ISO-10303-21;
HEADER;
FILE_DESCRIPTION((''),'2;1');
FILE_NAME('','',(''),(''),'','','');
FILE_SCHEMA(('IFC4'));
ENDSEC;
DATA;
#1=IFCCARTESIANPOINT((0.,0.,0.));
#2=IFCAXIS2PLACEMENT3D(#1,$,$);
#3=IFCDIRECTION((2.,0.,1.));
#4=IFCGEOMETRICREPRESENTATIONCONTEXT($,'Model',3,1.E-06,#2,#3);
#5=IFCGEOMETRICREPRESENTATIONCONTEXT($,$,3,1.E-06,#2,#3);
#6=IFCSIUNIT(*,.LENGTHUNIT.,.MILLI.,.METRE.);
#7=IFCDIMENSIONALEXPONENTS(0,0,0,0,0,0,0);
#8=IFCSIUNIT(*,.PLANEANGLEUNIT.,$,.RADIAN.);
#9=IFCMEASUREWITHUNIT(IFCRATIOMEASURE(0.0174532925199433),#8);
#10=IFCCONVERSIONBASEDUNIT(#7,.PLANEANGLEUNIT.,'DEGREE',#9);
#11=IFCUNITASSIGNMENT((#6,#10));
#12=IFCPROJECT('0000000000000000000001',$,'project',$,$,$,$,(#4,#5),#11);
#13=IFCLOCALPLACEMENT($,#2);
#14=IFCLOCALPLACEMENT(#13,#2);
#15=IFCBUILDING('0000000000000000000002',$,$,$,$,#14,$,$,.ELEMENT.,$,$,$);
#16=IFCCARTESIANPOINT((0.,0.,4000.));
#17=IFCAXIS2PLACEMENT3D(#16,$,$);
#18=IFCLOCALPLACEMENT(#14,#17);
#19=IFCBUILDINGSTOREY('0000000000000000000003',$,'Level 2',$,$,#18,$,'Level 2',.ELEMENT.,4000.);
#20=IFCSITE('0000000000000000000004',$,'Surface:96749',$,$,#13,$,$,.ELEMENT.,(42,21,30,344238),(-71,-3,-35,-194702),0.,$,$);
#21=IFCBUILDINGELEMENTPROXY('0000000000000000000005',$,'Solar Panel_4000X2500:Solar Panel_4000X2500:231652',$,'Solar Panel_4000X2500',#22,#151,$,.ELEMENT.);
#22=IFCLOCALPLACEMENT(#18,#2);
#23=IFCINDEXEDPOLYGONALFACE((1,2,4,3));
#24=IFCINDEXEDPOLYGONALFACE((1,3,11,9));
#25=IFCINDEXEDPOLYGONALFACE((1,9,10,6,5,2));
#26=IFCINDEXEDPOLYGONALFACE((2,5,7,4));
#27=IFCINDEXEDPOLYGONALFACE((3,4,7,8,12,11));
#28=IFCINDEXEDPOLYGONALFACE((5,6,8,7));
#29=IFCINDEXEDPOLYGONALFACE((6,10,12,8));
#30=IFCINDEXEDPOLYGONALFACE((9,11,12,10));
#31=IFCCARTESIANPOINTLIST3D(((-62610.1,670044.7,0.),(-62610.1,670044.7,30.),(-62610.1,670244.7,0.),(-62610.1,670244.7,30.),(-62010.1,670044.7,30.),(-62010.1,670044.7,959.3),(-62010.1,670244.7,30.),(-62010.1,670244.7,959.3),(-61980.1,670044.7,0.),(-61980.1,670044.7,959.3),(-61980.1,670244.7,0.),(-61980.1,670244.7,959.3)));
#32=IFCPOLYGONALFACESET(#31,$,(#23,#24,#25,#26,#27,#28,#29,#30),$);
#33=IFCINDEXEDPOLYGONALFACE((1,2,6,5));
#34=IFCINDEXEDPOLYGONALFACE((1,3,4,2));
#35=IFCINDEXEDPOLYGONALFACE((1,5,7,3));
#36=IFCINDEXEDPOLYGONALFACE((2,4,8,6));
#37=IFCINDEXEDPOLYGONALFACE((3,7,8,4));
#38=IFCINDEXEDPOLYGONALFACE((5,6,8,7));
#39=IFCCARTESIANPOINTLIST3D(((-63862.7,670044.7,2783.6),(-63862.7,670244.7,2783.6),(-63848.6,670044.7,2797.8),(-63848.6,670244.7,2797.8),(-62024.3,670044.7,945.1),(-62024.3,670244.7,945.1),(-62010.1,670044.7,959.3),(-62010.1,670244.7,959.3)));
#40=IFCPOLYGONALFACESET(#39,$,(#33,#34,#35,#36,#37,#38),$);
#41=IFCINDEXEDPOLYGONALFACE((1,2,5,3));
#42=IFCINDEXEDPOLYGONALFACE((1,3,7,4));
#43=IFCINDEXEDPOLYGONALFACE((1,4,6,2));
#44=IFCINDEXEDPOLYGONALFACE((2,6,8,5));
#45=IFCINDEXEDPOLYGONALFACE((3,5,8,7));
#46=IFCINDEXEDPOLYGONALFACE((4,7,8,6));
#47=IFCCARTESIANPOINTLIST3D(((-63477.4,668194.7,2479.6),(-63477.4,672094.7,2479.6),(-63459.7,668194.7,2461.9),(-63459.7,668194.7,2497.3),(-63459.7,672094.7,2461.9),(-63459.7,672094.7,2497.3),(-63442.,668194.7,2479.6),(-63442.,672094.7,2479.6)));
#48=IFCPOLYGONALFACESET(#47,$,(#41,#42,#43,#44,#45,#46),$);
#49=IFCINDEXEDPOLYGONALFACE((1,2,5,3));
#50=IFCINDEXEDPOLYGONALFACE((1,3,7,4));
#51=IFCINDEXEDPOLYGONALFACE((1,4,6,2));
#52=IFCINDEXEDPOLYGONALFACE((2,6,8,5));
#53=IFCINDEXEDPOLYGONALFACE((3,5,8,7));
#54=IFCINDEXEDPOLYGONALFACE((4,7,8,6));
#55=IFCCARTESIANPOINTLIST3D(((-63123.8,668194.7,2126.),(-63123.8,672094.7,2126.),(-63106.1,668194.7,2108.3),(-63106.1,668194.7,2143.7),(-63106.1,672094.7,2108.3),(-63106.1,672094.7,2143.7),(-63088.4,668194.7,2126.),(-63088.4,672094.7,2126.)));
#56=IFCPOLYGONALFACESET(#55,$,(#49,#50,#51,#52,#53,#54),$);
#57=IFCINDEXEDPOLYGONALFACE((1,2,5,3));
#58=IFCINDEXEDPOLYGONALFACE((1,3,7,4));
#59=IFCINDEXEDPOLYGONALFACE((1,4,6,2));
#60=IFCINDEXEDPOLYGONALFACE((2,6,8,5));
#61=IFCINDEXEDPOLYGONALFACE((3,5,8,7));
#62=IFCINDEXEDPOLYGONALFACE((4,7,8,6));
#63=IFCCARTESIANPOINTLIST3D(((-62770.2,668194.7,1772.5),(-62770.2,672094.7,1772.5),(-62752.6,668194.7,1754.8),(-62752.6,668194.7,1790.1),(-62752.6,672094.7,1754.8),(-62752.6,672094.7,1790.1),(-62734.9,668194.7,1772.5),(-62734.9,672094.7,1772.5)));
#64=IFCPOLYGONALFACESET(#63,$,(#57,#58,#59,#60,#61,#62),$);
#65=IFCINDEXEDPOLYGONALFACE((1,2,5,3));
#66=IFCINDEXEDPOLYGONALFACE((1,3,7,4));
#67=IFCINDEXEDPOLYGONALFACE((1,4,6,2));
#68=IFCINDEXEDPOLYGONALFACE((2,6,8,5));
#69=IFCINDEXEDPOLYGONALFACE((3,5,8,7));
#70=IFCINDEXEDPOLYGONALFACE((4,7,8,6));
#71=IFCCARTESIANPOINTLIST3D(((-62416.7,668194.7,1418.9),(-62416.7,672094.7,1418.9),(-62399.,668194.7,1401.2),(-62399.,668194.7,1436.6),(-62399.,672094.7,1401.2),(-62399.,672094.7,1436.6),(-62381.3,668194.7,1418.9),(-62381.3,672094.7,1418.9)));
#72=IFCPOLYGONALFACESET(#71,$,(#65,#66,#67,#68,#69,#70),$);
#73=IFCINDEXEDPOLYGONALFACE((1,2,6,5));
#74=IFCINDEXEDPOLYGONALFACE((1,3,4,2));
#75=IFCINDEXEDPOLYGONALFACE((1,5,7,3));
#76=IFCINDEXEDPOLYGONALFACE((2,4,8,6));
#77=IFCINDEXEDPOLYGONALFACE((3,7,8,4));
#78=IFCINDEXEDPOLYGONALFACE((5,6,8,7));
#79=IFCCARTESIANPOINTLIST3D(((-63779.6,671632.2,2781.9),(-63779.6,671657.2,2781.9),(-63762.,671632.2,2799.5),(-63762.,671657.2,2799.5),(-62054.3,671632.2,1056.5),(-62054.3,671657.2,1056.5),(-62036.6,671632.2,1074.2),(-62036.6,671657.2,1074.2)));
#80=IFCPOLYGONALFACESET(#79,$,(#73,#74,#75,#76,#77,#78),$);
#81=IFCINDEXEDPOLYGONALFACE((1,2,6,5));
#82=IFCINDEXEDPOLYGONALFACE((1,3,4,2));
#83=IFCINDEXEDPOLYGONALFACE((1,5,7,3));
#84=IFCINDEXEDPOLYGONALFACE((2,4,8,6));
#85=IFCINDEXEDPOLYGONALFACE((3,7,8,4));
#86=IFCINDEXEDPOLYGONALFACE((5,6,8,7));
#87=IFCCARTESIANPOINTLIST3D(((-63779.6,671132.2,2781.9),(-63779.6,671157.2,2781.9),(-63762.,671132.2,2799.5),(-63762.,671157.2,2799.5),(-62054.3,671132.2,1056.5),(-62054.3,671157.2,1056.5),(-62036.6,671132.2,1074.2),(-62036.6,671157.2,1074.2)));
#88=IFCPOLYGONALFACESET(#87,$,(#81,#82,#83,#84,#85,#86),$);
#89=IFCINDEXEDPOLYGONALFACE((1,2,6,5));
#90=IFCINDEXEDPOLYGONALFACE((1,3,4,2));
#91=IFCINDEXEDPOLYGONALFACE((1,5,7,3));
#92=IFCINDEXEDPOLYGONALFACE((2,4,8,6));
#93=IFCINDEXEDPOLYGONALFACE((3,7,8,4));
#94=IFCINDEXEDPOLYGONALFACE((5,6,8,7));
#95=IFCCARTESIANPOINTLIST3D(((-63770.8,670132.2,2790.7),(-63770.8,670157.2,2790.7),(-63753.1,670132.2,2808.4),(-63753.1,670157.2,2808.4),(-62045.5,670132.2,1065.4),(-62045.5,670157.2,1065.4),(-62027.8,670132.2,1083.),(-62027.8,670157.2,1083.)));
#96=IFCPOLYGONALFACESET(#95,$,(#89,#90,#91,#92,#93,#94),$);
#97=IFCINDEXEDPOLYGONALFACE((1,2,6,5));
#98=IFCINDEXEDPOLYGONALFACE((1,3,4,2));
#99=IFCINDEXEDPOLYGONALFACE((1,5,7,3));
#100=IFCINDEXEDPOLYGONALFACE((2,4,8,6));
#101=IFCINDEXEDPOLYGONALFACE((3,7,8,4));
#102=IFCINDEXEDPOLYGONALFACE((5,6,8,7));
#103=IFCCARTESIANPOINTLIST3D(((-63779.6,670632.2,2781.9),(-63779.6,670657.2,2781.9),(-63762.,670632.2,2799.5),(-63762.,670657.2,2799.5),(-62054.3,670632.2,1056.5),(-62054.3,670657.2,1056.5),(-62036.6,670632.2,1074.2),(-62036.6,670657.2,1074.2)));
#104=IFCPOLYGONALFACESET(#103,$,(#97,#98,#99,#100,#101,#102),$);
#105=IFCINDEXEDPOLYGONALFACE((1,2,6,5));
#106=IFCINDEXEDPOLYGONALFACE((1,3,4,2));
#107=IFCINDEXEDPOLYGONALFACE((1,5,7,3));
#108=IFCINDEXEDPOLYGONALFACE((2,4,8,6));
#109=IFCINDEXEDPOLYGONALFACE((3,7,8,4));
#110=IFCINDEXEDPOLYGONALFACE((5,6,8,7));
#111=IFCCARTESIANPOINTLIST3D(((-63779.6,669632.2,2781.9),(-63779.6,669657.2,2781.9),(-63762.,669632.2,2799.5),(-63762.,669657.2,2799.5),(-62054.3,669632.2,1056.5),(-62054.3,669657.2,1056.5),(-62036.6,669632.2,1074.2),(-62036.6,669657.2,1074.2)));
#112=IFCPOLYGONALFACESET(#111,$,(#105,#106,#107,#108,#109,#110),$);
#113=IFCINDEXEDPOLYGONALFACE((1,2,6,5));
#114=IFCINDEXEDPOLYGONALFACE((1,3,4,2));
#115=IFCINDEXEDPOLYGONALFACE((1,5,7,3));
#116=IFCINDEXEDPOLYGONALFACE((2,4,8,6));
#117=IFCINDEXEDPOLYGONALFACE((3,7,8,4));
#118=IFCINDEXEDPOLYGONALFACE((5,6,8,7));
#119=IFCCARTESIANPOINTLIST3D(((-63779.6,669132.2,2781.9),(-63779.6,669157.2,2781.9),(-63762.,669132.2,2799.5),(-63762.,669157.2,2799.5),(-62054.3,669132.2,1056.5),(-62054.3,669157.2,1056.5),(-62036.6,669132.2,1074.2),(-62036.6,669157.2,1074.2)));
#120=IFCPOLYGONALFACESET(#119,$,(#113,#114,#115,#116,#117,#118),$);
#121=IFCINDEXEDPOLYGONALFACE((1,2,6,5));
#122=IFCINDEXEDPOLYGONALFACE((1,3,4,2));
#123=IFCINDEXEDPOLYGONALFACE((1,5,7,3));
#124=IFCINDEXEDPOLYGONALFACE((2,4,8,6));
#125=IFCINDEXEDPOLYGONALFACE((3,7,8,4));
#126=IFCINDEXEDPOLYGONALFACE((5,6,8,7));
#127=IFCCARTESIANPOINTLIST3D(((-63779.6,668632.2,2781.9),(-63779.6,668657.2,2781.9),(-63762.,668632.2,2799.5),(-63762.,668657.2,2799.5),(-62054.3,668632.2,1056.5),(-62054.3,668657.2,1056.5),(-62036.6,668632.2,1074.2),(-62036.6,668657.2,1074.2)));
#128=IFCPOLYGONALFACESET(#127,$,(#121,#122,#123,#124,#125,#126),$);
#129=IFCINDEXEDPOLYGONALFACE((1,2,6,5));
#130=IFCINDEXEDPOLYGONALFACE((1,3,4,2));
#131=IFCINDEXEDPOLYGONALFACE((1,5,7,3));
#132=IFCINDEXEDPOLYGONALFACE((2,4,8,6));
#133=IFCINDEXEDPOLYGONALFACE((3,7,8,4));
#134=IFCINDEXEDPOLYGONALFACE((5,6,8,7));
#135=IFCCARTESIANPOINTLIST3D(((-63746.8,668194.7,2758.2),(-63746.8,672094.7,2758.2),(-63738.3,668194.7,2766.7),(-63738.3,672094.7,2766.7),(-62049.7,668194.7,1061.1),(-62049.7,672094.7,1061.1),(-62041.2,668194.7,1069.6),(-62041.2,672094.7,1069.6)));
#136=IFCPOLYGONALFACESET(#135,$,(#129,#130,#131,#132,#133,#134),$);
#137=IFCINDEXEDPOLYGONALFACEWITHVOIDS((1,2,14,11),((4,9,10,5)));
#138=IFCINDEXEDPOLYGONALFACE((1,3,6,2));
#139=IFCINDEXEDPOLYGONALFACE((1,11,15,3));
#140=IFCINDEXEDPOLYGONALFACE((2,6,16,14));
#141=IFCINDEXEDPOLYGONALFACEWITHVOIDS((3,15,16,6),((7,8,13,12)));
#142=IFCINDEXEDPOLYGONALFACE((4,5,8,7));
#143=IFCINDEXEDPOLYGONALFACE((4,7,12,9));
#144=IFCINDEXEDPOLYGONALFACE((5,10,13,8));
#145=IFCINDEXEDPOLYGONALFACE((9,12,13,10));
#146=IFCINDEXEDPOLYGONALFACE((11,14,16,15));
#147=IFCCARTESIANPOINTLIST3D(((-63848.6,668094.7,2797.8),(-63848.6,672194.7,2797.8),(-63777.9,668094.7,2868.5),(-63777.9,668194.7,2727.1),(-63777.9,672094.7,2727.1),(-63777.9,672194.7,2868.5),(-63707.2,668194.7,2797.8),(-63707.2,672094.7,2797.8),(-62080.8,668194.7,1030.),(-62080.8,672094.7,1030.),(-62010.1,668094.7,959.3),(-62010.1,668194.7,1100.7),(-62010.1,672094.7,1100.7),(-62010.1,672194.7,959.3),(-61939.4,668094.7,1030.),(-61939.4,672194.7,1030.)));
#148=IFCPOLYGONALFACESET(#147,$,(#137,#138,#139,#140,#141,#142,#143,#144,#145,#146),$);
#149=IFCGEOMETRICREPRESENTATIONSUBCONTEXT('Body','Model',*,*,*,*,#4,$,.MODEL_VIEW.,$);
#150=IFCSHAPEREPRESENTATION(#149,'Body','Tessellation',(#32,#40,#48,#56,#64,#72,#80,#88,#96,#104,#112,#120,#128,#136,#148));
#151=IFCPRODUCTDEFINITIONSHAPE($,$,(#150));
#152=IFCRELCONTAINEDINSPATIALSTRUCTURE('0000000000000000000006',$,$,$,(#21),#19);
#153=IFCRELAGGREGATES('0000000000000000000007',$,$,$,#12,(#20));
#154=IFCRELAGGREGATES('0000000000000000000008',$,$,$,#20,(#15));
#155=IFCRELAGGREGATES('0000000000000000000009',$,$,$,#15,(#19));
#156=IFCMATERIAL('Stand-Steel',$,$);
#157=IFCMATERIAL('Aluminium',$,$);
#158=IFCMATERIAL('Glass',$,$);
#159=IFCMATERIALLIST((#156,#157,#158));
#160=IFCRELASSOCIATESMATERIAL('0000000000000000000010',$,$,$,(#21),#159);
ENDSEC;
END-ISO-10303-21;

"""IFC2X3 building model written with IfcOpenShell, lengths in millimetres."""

from ifc_helpers import new_model, entity, si_unit, converted_unit, direction, frame, frame_2d, origin, origin_2d_with_axis, place, context, subcontext, project, spatial, polyline, rectangle, outline, extrude, source, transform, mapped, material, material_list, element, save


model = new_model("IFC2X3")

# Units and contexts
model_context = context("Model", 3, precision=1e-06, world=origin(), true_north=direction((2.0, 0.0, 1.0)))
context_of_model = context(None, 3, precision=1e-06, world=origin(), true_north=direction((2.0, 0.0, 1.0)))
body_context = subcontext(model_context, "Body", "Model", "MODEL_VIEW")
ifc_project = project(units=[si_unit("LENGTHUNIT", "METRE", prefix="MILLI"), converted_unit("PLANEANGLEUNIT", "DEGREE", entity("IfcRatioMeasure", 0.0174532925199433), si_unit("PLANEANGLEUNIT", "RADIAN"), dimensions=[0, 0, 0, 0, 0, 0, 0])], contexts=[model_context, context_of_model])

# Site, building, storey
site_placement = place(None, origin())
site = spatial("IfcSite", under=ifc_project, at=site_placement, Name="Surface:96749", CompositionType="ELEMENT", RefLatitude=(42, 21, 30, 344238), RefLongitude=(-71, -3, -35, -194702), RefElevation=0.0)
building_placement = place(site_placement, origin())
building = spatial("IfcBuilding", under=site, at=building_placement, CompositionType="ELEMENT")
storey_placement = place(building_placement, frame((0.0, 0.0, 4000.0)))
storey = spatial("IfcBuildingStorey", under=building, at=storey_placement, Name="Level 2", LongName="Level 2", CompositionType="ELEMENT", Elevation=4000.0)

# Building element proxy
ifc_material_1 = material(Name="Stand-Steel")
ifc_material_2 = material(Name="Aluminium")
ifc_material_3 = material(Name="Glass")
shared_shape = source(origin(), body_context, "Body", "SweptSolid", [
    extrude(outline(polyline([(-629.5, -220.0), (329.8, -220.0), (329.8, 410.0), (299.8, 410.0), (299.8, -190.0), (-629.5, -190.0), (-629.5, -220.0)])), frame((-190.0, -100.0, 299.8), z_axis=(0.0, 1.0, 0.0), x_axis=(0.0, 0.0, -1.0)), (0.0, 0.0, 1.0), 200.0),
    extrude(rectangle(XDim=20.0, YDim=200.0, at=frame_2d((0.0, 0.0), x_axis=(0.0, 1.0))), frame((-7.1, 0.0, 922.2), z_axis=(-0.707107, 0.0, 0.707107), x_axis=(0.0, 1.0, 0.0)), (0.0, 0.0, 1.0), 2600.0),
    extrude(rectangle(XDim=25.0, YDim=25.0, at=frame_2d((0.0, 0.0), x_axis=(1.0, 0.0))), frame((-1449.6, -1950.0, 2449.6), z_axis=(0.0, 1.0, 0.0), x_axis=(-0.707107, 0.0, -0.707107)), (0.0, 0.0, 1.0), 3900.0),
    extrude(rectangle(XDim=25.0, YDim=25.0, at=origin_2d_with_axis()), frame((-1096.0, -1950.0, 2096.0), z_axis=(0.0, 1.0, 0.0), x_axis=(-0.707107, 0.0, -0.707107)), (0.0, 0.0, 1.0), 3900.0),
    extrude(rectangle(XDim=25.0, YDim=25.0, at=origin_2d_with_axis()), frame((-742.5, -1950.0, 1742.5), z_axis=(0.0, 1.0, 0.0), x_axis=(-0.707107, 0.0, -0.707107)), (0.0, 0.0, 1.0), 3900.0),
    extrude(rectangle(XDim=25.0, YDim=25.0, at=frame_2d((0.0, 0.0), x_axis=(1.0, 0.0))), frame((-388.9, -1950.0, 1388.9), z_axis=(0.0, 1.0, 0.0), x_axis=(-0.707107, 0.0, -0.707107)), (0.0, 0.0, 1.0), 3900.0),
    extrude(rectangle(XDim=25.0, YDim=25.0, at=frame_2d((0.0, 0.0), x_axis=(0.0, 1.0))), frame((-35.4, 1500.0, 1035.4), z_axis=(-0.707107, 0.0, 0.707107), x_axis=(0.0, 1.0, 0.0)), (0.0, 0.0, 1.0), 2440.0),
    extrude(rectangle(XDim=25.0, YDim=25.0, at=frame_2d((0.0, 0.0), x_axis=(0.0, 1.0))), frame((-35.4, 1000.0, 1035.4), z_axis=(-0.707107, 0.0, 0.707107), x_axis=(0.0, 1.0, 0.0)), (0.0, 0.0, 1.0), 2440.0),
    extrude(rectangle(XDim=25.0, YDim=25.0, at=frame_2d((0.0, 0.0), x_axis=(0.0, 1.0))), frame((-26.5, 0.0, 1044.2), z_axis=(-0.707107, 0.0, 0.707107), x_axis=(0.0, -1.0, 0.0)), (0.0, 0.0, 1.0), 2440.0),
    extrude(rectangle(XDim=25.0, YDim=25.0, at=frame_2d((0.0, 0.0), x_axis=(0.0, 1.0))), frame((-35.4, 500.0, 1035.4), z_axis=(-0.707107, 0.0, 0.707107), x_axis=(0.0, 1.0, 0.0)), (0.0, 0.0, 1.0), 2440.0),
    extrude(rectangle(XDim=25.0, YDim=25.0, at=frame_2d((0.0, 0.0), x_axis=(0.0, 1.0))), frame((-35.4, -500.0, 1035.4), z_axis=(-0.707107, 0.0, 0.707107), x_axis=(0.0, 1.0, 0.0)), (0.0, 0.0, 1.0), 2440.0),
    extrude(rectangle(XDim=25.0, YDim=25.0, at=frame_2d((0.0, 0.0), x_axis=(0.0, 1.0))), frame((-35.4, -1000.0, 1035.4), z_axis=(-0.707107, 0.0, 0.707107), x_axis=(0.0, 1.0, 0.0)), (0.0, 0.0, 1.0), 2440.0),
    extrude(rectangle(XDim=25.0, YDim=25.0, at=frame_2d((0.0, 0.0), x_axis=(0.0, 1.0))), frame((-35.4, -1500.0, 1035.4), z_axis=(-0.707107, 0.0, 0.707107), x_axis=(0.0, 1.0, 0.0)), (0.0, 0.0, 1.0), 2440.0),
    extrude(rectangle(XDim=2400.0, YDim=12.0, at=frame_2d((0.0, 0.0), x_axis=(1.0, 0.0))), frame((-883.9, -1950.0, 1883.9), z_axis=(0.0, 1.0, 0.0), x_axis=(0.707107, 0.0, -0.707107)), (0.0, 0.0, 1.0), 3900.0),
    extrude(outline(polyline([(-2050.0, -1300.0), (2050.0, -1300.0), (2050.0, 1300.0), (-2050.0, 1300.0), (-2050.0, -1300.0)]), holes=[polyline([(1950.0, -1200.0), (-1950.0, -1200.0), (-1950.0, 1200.0), (1950.0, 1200.0), (1950.0, -1200.0)])]), frame((-919.2, 0.0, 1848.5), z_axis=(0.707107, 0.0, 0.707107), x_axis=(0.0, 1.0, 0.0)), (0.0, 0.0, 1.0), 100.0),
])
ifc_material_list_1 = material_list([ifc_material_1, ifc_material_2, ifc_material_3])
proxy_1_placement = place(storey_placement, frame((-62010.1, 670144.7, 30.0)))
element("IfcBuildingElementProxy", 1, at=proxy_1_placement, inside=storey, material=ifc_material_list_1, Name="Solar Panel_4000X2500:Solar Panel_4000X2500:231652", ObjectType="Solar Panel_4000X2500", CompositionType="ELEMENT", context=body_context, shape_type="MappedRepresentation", body=[
    mapped(shared_shape, transform((0.0, 0.0, 0.0), scale=1.0)),
])

save(model, "model.ifc")
